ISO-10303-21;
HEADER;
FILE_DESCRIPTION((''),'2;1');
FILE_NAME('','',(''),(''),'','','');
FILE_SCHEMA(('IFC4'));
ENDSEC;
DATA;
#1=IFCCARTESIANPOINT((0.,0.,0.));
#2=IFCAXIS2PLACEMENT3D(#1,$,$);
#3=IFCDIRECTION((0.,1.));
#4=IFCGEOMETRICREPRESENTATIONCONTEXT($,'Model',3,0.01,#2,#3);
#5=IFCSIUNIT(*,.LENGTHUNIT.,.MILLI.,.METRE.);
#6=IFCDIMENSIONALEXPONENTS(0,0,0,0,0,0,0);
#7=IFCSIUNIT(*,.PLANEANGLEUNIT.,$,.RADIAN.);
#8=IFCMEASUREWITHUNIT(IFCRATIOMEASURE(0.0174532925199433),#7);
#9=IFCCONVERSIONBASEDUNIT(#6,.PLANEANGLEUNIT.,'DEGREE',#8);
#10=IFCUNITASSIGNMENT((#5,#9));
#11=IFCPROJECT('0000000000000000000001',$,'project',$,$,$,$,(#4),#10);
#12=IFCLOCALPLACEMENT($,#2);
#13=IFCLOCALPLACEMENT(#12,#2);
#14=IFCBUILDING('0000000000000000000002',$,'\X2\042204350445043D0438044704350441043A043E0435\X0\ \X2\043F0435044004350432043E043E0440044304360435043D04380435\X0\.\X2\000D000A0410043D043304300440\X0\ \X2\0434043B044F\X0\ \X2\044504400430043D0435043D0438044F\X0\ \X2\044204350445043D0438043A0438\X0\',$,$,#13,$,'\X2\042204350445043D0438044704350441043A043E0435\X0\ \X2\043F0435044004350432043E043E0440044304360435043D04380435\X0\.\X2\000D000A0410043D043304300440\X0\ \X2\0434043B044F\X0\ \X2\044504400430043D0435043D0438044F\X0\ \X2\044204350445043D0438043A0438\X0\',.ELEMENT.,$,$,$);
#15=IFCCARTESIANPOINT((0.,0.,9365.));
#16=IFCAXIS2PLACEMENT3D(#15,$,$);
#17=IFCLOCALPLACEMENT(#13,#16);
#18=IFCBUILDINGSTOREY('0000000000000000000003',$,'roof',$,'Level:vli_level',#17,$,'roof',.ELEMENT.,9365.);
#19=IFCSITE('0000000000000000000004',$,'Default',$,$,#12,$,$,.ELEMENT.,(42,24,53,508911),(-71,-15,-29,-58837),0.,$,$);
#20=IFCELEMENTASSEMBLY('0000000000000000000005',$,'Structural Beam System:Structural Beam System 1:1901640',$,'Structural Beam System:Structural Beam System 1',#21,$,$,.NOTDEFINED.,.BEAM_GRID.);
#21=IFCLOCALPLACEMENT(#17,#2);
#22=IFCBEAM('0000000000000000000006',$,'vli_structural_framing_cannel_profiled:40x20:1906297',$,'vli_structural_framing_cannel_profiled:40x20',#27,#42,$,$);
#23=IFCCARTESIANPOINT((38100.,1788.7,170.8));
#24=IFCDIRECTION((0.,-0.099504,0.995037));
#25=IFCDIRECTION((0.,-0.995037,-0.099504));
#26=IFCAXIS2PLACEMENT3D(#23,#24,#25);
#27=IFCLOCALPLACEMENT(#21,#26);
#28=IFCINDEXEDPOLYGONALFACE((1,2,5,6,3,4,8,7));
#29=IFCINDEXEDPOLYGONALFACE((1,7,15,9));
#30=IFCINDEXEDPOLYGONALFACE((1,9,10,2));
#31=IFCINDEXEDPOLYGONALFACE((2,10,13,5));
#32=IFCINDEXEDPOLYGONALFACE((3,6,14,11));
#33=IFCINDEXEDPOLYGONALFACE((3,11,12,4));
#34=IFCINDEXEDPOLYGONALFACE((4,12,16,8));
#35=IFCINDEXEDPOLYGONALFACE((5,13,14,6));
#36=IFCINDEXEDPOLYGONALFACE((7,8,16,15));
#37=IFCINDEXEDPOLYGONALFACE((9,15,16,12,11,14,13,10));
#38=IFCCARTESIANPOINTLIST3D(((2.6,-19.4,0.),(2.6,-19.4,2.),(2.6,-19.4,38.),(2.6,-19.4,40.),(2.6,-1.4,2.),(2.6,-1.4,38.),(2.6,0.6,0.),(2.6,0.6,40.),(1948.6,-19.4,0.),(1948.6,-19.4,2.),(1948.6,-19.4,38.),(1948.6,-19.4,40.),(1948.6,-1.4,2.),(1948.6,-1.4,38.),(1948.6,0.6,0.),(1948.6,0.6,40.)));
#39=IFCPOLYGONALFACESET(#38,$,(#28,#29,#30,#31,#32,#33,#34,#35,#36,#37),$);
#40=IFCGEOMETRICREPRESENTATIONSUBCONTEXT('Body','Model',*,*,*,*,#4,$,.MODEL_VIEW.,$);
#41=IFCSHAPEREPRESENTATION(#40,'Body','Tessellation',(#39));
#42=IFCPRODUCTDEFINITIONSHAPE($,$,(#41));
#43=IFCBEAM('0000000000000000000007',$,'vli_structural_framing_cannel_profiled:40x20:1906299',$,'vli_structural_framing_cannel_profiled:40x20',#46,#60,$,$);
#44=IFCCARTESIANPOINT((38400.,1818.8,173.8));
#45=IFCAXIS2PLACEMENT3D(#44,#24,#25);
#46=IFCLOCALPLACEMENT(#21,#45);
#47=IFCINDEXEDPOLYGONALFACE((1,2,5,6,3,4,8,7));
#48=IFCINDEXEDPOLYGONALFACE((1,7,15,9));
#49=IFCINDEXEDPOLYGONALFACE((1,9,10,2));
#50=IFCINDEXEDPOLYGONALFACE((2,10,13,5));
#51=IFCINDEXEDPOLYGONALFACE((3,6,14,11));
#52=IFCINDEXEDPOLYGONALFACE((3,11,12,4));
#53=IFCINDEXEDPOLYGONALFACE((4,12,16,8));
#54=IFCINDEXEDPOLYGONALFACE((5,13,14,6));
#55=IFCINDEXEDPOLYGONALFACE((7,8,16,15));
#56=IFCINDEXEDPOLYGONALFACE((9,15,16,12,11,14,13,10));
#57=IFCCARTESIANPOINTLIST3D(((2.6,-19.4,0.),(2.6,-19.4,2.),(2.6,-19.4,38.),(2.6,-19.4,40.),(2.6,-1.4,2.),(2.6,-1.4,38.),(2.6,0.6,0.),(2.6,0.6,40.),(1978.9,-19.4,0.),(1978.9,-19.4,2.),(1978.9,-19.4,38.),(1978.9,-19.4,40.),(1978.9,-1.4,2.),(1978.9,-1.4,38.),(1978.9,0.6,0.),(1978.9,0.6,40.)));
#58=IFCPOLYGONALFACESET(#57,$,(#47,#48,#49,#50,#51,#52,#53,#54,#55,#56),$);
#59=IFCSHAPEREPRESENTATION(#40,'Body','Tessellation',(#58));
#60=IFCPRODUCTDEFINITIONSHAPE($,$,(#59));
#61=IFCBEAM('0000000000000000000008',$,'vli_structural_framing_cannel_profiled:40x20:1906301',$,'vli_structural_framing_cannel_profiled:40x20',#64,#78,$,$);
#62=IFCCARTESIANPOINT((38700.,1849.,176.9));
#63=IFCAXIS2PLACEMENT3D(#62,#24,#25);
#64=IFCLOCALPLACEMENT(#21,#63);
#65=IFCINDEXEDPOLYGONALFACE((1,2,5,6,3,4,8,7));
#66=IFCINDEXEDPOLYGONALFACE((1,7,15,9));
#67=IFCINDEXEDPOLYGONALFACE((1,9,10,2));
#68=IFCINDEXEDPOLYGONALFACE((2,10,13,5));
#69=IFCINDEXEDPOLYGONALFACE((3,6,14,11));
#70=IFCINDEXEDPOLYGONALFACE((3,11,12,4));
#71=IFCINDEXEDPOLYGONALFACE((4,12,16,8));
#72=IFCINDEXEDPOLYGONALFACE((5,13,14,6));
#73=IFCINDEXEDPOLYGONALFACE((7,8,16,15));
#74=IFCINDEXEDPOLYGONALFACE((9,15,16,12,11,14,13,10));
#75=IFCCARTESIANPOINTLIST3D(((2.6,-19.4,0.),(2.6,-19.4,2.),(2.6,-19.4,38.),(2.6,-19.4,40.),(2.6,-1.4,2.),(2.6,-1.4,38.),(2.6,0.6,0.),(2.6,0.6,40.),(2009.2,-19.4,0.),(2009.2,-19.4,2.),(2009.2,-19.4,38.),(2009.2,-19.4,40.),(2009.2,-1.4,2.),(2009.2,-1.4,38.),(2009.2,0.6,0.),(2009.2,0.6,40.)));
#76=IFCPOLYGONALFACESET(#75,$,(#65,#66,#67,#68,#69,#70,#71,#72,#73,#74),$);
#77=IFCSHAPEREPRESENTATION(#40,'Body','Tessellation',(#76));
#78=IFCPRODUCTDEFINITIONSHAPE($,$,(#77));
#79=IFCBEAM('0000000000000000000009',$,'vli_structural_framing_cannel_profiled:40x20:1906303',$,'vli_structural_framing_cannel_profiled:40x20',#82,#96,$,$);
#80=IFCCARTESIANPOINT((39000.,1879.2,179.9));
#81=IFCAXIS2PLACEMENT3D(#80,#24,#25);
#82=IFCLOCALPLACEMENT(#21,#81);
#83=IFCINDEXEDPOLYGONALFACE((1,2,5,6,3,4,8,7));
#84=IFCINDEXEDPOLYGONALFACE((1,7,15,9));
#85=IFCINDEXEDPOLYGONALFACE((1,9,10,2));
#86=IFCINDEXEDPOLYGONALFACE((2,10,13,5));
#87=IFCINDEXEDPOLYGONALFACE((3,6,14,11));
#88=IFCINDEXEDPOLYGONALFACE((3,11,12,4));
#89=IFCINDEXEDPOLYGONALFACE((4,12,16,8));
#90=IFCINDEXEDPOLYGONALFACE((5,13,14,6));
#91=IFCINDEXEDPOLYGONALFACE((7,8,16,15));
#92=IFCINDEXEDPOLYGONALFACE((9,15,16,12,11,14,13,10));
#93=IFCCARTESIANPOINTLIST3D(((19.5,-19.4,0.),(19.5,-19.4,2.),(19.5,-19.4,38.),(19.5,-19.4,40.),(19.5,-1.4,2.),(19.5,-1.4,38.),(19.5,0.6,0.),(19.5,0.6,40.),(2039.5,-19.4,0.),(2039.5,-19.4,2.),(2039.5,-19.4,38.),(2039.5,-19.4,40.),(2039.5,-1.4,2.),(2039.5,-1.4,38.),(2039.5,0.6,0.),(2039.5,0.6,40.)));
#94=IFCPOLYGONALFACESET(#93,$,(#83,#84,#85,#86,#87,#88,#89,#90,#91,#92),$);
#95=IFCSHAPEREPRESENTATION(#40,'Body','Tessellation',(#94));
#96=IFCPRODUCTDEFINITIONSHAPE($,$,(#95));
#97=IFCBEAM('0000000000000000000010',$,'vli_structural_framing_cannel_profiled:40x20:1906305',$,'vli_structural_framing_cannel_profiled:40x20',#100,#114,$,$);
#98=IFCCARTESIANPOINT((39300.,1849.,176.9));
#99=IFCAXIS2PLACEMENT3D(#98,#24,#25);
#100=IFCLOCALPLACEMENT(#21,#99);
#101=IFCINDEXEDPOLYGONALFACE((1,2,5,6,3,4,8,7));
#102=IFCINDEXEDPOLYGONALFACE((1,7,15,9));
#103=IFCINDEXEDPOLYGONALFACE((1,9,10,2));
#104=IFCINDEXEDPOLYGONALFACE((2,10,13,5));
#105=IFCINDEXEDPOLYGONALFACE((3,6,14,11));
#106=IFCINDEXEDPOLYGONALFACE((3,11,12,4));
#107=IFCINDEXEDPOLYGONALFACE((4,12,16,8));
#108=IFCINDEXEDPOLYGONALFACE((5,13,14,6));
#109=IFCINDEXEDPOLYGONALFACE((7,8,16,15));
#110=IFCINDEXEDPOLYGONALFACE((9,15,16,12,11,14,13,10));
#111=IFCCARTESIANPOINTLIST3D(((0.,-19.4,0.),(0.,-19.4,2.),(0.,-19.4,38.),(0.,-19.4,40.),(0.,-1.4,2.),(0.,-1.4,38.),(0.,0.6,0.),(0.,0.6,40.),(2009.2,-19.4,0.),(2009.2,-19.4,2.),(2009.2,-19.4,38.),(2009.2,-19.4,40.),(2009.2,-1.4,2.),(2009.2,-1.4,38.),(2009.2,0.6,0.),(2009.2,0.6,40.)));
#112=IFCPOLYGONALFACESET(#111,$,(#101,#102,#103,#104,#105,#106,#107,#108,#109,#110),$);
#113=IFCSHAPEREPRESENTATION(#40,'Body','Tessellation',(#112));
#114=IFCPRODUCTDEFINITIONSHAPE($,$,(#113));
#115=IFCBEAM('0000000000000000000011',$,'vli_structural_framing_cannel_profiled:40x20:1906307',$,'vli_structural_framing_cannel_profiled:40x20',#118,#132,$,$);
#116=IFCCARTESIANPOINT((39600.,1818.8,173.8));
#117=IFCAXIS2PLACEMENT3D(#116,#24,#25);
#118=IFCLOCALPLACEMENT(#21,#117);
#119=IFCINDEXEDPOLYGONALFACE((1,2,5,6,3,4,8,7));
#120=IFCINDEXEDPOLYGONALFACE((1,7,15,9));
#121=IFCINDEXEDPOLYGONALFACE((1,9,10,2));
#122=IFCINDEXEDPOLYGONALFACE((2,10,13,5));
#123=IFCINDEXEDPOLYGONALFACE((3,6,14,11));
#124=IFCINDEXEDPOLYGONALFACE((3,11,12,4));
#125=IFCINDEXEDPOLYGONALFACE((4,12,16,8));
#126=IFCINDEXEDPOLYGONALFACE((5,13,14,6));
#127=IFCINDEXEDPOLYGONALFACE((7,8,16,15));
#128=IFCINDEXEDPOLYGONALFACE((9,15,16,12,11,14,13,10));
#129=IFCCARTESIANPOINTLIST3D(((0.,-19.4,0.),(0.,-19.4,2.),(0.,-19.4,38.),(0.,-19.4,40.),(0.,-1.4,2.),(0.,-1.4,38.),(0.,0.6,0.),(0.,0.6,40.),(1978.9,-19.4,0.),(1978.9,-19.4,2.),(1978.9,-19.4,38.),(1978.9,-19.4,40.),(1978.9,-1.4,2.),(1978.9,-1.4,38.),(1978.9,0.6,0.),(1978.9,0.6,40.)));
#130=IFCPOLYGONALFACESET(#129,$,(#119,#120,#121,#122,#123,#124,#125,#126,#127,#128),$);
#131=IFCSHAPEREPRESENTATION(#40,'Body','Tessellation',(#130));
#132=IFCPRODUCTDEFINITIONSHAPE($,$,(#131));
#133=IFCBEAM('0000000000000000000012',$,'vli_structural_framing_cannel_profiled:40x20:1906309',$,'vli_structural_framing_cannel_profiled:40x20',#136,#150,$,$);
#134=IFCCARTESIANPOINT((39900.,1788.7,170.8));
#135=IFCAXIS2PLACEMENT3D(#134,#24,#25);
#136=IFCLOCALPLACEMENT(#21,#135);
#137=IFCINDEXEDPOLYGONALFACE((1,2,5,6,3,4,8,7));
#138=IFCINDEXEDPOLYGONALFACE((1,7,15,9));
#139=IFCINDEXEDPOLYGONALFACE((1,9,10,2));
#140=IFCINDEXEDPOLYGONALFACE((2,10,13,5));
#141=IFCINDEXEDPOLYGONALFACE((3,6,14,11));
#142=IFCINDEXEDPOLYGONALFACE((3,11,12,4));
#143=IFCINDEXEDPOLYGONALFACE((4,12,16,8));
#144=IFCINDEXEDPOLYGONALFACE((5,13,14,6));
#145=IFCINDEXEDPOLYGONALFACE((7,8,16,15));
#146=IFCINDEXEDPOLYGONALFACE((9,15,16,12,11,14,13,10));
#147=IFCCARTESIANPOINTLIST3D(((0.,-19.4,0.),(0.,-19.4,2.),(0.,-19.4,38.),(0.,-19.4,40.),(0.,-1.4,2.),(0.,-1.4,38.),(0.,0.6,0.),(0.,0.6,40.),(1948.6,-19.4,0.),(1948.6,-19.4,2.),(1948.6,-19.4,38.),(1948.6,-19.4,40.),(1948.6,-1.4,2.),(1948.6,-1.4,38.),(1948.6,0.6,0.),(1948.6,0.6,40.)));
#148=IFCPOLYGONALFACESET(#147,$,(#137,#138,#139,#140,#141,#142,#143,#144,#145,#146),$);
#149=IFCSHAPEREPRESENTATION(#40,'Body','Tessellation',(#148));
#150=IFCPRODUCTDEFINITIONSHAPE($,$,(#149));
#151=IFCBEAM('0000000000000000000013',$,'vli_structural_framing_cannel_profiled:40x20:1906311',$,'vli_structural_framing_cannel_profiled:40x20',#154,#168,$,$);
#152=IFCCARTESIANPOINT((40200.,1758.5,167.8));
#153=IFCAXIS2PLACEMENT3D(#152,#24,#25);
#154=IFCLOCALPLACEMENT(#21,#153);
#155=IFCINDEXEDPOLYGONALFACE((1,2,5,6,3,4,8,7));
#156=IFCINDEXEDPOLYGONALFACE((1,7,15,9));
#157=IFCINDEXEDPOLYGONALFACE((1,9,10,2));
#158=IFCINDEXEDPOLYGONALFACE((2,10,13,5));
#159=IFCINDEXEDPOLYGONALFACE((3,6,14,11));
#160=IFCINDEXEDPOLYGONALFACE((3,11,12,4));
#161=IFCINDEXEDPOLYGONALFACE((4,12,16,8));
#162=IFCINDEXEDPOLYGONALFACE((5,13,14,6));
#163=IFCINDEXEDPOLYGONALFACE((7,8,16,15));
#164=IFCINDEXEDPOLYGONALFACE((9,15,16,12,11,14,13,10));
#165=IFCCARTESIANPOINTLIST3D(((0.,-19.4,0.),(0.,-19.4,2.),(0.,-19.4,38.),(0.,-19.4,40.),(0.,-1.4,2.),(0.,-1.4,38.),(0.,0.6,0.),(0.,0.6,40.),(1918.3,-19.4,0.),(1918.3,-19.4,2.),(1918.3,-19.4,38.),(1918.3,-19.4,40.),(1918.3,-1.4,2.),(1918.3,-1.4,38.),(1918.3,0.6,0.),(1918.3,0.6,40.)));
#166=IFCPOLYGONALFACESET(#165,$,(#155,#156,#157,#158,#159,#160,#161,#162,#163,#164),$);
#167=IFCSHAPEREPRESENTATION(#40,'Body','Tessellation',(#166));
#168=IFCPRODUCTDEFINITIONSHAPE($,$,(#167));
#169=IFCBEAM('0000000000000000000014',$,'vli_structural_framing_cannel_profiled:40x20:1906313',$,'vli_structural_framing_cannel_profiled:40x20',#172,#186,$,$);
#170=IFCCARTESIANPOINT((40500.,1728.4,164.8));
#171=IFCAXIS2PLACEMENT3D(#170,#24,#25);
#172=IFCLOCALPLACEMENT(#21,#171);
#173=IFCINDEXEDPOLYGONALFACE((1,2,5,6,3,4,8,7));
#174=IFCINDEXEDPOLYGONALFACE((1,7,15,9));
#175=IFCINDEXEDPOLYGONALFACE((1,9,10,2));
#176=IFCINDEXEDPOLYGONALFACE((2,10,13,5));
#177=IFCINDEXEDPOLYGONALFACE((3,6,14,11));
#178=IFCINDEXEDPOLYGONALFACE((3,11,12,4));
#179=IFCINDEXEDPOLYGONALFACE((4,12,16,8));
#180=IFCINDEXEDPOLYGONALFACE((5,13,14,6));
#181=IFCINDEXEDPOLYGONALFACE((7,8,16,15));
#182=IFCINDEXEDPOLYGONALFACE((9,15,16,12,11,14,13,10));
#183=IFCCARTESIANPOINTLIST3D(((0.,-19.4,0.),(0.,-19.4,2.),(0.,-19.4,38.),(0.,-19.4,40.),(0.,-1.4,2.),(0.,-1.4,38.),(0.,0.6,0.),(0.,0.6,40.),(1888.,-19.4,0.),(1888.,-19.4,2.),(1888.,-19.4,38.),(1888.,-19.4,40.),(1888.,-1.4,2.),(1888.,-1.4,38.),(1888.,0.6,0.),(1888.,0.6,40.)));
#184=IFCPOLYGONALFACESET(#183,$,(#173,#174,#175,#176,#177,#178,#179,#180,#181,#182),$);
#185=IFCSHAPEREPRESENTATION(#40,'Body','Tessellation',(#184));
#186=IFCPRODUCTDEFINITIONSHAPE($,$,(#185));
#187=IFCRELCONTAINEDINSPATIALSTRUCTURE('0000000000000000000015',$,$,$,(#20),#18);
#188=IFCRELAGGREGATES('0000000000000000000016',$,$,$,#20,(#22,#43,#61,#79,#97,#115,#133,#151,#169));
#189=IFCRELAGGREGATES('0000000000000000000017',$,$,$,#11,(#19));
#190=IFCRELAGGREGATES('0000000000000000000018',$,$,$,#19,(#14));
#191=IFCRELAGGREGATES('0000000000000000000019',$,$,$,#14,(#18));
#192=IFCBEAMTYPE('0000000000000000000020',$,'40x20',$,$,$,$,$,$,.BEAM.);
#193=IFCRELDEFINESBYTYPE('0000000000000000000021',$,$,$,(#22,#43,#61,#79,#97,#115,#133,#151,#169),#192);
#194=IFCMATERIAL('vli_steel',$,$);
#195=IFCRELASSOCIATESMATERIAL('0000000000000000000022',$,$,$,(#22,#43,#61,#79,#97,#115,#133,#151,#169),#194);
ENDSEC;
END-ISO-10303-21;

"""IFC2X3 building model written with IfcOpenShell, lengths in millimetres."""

from ifc_helpers import new_model, entity, si_unit, converted_unit, direction, frame, origin, place, context, subcontext, project, spatial, polyline, outline, extrude, material, type_object, element, aggregate, save


model = new_model("IFC2X3")

# Units and contexts
model_context = context("Model", 3, precision=0.01, world=origin(), true_north=direction((0.0, 1.0)))
body_context = subcontext(model_context, "Body", "Model", "MODEL_VIEW")
ifc_project = project(units=[si_unit("LENGTHUNIT", "METRE", prefix="MILLI"), converted_unit("PLANEANGLEUNIT", "DEGREE", entity("IfcRatioMeasure", 0.0174532925199433), si_unit("PLANEANGLEUNIT", "RADIAN"), dimensions=[0, 0, 0, 0, 0, 0, 0])], contexts=[model_context])

# Site, building, storey
site_placement = place(None, origin())
site = spatial("IfcSite", under=ifc_project, at=site_placement, Name="Default", CompositionType="ELEMENT", RefLatitude=(42, 24, 53, 508911), RefLongitude=(-71, -15, -29, -58837), RefElevation=0.0)
building_placement = place(site_placement, origin())
building = spatial("IfcBuilding", under=site, at=building_placement, Name="Техническое перевооружение.\r\nАнгар для хранения техники", LongName="Техническое перевооружение.\r\nАнгар для хранения техники", CompositionType="ELEMENT")
storey_placement = place(building_placement, frame((0.0, 0.0, 9365.0)))
storey = spatial("IfcBuildingStorey", under=building, at=storey_placement, Name="roof", ObjectType="Level:vli_level", LongName="roof", CompositionType="ELEMENT", Elevation=9365.0)

# Element assembly, beams
assembly_1_placement = place(storey_placement, origin())
assembly_1 = element("IfcElementAssembly", 1, at=assembly_1_placement, inside=storey, Name="Structural Beam System:Structural Beam System 1:1901640", ObjectType="Structural Beam System:Structural Beam System 1", AssemblyPlace="NOTDEFINED", PredefinedType="BEAM_GRID")
ifc_material = material(Name="vli_steel")
beam_type = type_object("IfcBeamType", Name="40x20", PredefinedType="BEAM")
beam_1_placement = place(assembly_1_placement, frame((38100.0, 1788.7, 170.8), z_axis=(0.0, -0.099504, 0.995037), x_axis=(0.0, -0.995037, -0.099504)))
beam_1 = element("IfcBeam", 2, at=beam_1_placement, type_object=beam_type, material=ifc_material, Name="vli_structural_framing_cannel_profiled:40x20:1906297", ObjectType="vli_structural_framing_cannel_profiled:40x20", context=body_context, shape_type="SweptSolid", body=[
    extrude(outline(polyline([(-20.0, -9.5), (-18.0, -9.5), (-18.0, 8.5), (18.0, 8.5), (18.0, -9.5), (20.0, -9.5), (20.0, 10.5), (-20.0, 10.5), (-20.0, -9.5)])), frame((2.6, -9.9, 20.0), z_axis=(1.0, 0.0, 0.0), x_axis=(0.0, 0.0, -1.0)), (0.0, 0.0, 1.0), 1946.1),
])
beam_2_placement = place(assembly_1_placement, frame((38400.0, 1818.8, 173.8), z_axis=(0.0, -0.099504, 0.995037), x_axis=(0.0, -0.995037, -0.099504)))
beam_2 = element("IfcBeam", 3, at=beam_2_placement, type_object=beam_type, material=ifc_material, Name="vli_structural_framing_cannel_profiled:40x20:1906299", ObjectType="vli_structural_framing_cannel_profiled:40x20", context=body_context, shape_type="SweptSolid", body=[
    extrude(outline(polyline([(-20.0, -9.5), (-18.0, -9.5), (-18.0, 8.5), (18.0, 8.5), (18.0, -9.5), (20.0, -9.5), (20.0, 10.5), (-20.0, 10.5), (-20.0, -9.5)])), frame((2.6, -9.9, 20.0), z_axis=(1.0, 0.0, 0.0), x_axis=(0.0, 0.0, -1.0)), (0.0, 0.0, 1.0), 1976.4),
])
beam_3_placement = place(assembly_1_placement, frame((38700.0, 1849.0, 176.9), z_axis=(0.0, -0.099504, 0.995037), x_axis=(0.0, -0.995037, -0.099504)))
beam_3 = element("IfcBeam", 4, at=beam_3_placement, type_object=beam_type, material=ifc_material, Name="vli_structural_framing_cannel_profiled:40x20:1906301", ObjectType="vli_structural_framing_cannel_profiled:40x20", context=body_context, shape_type="SweptSolid", body=[
    extrude(outline(polyline([(-20.0, -9.5), (-18.0, -9.5), (-18.0, 8.5), (18.0, 8.5), (18.0, -9.5), (20.0, -9.5), (20.0, 10.5), (-20.0, 10.5), (-20.0, -9.5)])), frame((2.6, -9.9, 20.0), z_axis=(1.0, 0.0, 0.0), x_axis=(0.0, 0.0, -1.0)), (0.0, 0.0, 1.0), 2006.7),
])
beam_4_placement = place(assembly_1_placement, frame((39000.0, 1879.2, 179.9), z_axis=(0.0, -0.099504, 0.995037), x_axis=(0.0, -0.995037, -0.099504)))
beam_4 = element("IfcBeam", 5, at=beam_4_placement, type_object=beam_type, material=ifc_material, Name="vli_structural_framing_cannel_profiled:40x20:1906303", ObjectType="vli_structural_framing_cannel_profiled:40x20", context=body_context, shape_type="SweptSolid", body=[
    extrude(outline(polyline([(-20.0, -9.5), (-18.0, -9.5), (-18.0, 8.5), (18.0, 8.5), (18.0, -9.5), (20.0, -9.5), (20.0, 10.5), (-20.0, 10.5), (-20.0, -9.5)])), frame((19.5, -9.9, 20.0), z_axis=(1.0, 0.0, 0.0), x_axis=(0.0, 0.0, -1.0)), (0.0, 0.0, 1.0), 2020.1),
])
beam_5_placement = place(assembly_1_placement, frame((39300.0, 1849.0, 176.9), z_axis=(0.0, -0.099504, 0.995037), x_axis=(0.0, -0.995037, -0.099504)))
beam_5 = element("IfcBeam", 6, at=beam_5_placement, type_object=beam_type, material=ifc_material, Name="vli_structural_framing_cannel_profiled:40x20:1906305", ObjectType="vli_structural_framing_cannel_profiled:40x20", context=body_context, shape_type="SweptSolid", body=[
    extrude(outline(polyline([(-20.0, -9.5), (-18.0, -9.5), (-18.0, 8.5), (18.0, 8.5), (18.0, -9.5), (20.0, -9.5), (20.0, 10.5), (-20.0, 10.5), (-20.0, -9.5)])), frame((0.0, -9.9, 20.0), z_axis=(1.0, 0.0, 0.0), x_axis=(0.0, 0.0, -1.0)), (0.0, 0.0, 1.0), 2009.2),
])
beam_6_placement = place(assembly_1_placement, frame((39600.0, 1818.8, 173.8), z_axis=(0.0, -0.099504, 0.995037), x_axis=(0.0, -0.995037, -0.099504)))
beam_6 = element("IfcBeam", 7, at=beam_6_placement, type_object=beam_type, material=ifc_material, Name="vli_structural_framing_cannel_profiled:40x20:1906307", ObjectType="vli_structural_framing_cannel_profiled:40x20", context=body_context, shape_type="SweptSolid", body=[
    extrude(outline(polyline([(-20.0, -9.5), (-18.0, -9.5), (-18.0, 8.5), (18.0, 8.5), (18.0, -9.5), (20.0, -9.5), (20.0, 10.5), (-20.0, 10.5), (-20.0, -9.5)])), frame((0.0, -9.9, 20.0), z_axis=(1.0, 0.0, 0.0), x_axis=(0.0, 0.0, -1.0)), (0.0, 0.0, 1.0), 1978.9),
])
beam_7_placement = place(assembly_1_placement, frame((39900.0, 1788.7, 170.8), z_axis=(0.0, -0.099504, 0.995037), x_axis=(0.0, -0.995037, -0.099504)))
beam_7 = element("IfcBeam", 8, at=beam_7_placement, type_object=beam_type, material=ifc_material, Name="vli_structural_framing_cannel_profiled:40x20:1906309", ObjectType="vli_structural_framing_cannel_profiled:40x20", context=body_context, shape_type="SweptSolid", body=[
    extrude(outline(polyline([(-20.0, -9.5), (-18.0, -9.5), (-18.0, 8.5), (18.0, 8.5), (18.0, -9.5), (20.0, -9.5), (20.0, 10.5), (-20.0, 10.5), (-20.0, -9.5)])), frame((0.0, -9.9, 20.0), z_axis=(1.0, 0.0, 0.0), x_axis=(0.0, 0.0, -1.0)), (0.0, 0.0, 1.0), 1948.6),
])
beam_8_placement = place(assembly_1_placement, frame((40200.0, 1758.5, 167.8), z_axis=(0.0, -0.099504, 0.995037), x_axis=(0.0, -0.995037, -0.099504)))
beam_8 = element("IfcBeam", 9, at=beam_8_placement, type_object=beam_type, material=ifc_material, Name="vli_structural_framing_cannel_profiled:40x20:1906311", ObjectType="vli_structural_framing_cannel_profiled:40x20", context=body_context, shape_type="SweptSolid", body=[
    extrude(outline(polyline([(-20.0, -9.5), (-18.0, -9.5), (-18.0, 8.5), (18.0, 8.5), (18.0, -9.5), (20.0, -9.5), (20.0, 10.5), (-20.0, 10.5), (-20.0, -9.5)])), frame((0.0, -9.9, 20.0), z_axis=(1.0, 0.0, 0.0), x_axis=(0.0, 0.0, -1.0)), (0.0, 0.0, 1.0), 1918.3),
])
beam_9_placement = place(assembly_1_placement, frame((40500.0, 1728.4, 164.8), z_axis=(0.0, -0.099504, 0.995037), x_axis=(0.0, -0.995037, -0.099504)))
beam_9 = element("IfcBeam", 10, at=beam_9_placement, type_object=beam_type, material=ifc_material, Name="vli_structural_framing_cannel_profiled:40x20:1906313", ObjectType="vli_structural_framing_cannel_profiled:40x20", context=body_context, shape_type="SweptSolid", body=[
    extrude(outline(polyline([(-20.0, -9.5), (-18.0, -9.5), (-18.0, 8.5), (18.0, 8.5), (18.0, -9.5), (20.0, -9.5), (20.0, 10.5), (-20.0, 10.5), (-20.0, -9.5)])), frame((0.0, -9.9, 20.0), z_axis=(1.0, 0.0, 0.0), x_axis=(0.0, 0.0, -1.0)), (0.0, 0.0, 1.0), 1888.0),
])
aggregate(assembly_1, [beam_1, beam_2, beam_3, beam_4, beam_5, beam_6, beam_7, beam_8, beam_9])

save(model, "model.ifc")
